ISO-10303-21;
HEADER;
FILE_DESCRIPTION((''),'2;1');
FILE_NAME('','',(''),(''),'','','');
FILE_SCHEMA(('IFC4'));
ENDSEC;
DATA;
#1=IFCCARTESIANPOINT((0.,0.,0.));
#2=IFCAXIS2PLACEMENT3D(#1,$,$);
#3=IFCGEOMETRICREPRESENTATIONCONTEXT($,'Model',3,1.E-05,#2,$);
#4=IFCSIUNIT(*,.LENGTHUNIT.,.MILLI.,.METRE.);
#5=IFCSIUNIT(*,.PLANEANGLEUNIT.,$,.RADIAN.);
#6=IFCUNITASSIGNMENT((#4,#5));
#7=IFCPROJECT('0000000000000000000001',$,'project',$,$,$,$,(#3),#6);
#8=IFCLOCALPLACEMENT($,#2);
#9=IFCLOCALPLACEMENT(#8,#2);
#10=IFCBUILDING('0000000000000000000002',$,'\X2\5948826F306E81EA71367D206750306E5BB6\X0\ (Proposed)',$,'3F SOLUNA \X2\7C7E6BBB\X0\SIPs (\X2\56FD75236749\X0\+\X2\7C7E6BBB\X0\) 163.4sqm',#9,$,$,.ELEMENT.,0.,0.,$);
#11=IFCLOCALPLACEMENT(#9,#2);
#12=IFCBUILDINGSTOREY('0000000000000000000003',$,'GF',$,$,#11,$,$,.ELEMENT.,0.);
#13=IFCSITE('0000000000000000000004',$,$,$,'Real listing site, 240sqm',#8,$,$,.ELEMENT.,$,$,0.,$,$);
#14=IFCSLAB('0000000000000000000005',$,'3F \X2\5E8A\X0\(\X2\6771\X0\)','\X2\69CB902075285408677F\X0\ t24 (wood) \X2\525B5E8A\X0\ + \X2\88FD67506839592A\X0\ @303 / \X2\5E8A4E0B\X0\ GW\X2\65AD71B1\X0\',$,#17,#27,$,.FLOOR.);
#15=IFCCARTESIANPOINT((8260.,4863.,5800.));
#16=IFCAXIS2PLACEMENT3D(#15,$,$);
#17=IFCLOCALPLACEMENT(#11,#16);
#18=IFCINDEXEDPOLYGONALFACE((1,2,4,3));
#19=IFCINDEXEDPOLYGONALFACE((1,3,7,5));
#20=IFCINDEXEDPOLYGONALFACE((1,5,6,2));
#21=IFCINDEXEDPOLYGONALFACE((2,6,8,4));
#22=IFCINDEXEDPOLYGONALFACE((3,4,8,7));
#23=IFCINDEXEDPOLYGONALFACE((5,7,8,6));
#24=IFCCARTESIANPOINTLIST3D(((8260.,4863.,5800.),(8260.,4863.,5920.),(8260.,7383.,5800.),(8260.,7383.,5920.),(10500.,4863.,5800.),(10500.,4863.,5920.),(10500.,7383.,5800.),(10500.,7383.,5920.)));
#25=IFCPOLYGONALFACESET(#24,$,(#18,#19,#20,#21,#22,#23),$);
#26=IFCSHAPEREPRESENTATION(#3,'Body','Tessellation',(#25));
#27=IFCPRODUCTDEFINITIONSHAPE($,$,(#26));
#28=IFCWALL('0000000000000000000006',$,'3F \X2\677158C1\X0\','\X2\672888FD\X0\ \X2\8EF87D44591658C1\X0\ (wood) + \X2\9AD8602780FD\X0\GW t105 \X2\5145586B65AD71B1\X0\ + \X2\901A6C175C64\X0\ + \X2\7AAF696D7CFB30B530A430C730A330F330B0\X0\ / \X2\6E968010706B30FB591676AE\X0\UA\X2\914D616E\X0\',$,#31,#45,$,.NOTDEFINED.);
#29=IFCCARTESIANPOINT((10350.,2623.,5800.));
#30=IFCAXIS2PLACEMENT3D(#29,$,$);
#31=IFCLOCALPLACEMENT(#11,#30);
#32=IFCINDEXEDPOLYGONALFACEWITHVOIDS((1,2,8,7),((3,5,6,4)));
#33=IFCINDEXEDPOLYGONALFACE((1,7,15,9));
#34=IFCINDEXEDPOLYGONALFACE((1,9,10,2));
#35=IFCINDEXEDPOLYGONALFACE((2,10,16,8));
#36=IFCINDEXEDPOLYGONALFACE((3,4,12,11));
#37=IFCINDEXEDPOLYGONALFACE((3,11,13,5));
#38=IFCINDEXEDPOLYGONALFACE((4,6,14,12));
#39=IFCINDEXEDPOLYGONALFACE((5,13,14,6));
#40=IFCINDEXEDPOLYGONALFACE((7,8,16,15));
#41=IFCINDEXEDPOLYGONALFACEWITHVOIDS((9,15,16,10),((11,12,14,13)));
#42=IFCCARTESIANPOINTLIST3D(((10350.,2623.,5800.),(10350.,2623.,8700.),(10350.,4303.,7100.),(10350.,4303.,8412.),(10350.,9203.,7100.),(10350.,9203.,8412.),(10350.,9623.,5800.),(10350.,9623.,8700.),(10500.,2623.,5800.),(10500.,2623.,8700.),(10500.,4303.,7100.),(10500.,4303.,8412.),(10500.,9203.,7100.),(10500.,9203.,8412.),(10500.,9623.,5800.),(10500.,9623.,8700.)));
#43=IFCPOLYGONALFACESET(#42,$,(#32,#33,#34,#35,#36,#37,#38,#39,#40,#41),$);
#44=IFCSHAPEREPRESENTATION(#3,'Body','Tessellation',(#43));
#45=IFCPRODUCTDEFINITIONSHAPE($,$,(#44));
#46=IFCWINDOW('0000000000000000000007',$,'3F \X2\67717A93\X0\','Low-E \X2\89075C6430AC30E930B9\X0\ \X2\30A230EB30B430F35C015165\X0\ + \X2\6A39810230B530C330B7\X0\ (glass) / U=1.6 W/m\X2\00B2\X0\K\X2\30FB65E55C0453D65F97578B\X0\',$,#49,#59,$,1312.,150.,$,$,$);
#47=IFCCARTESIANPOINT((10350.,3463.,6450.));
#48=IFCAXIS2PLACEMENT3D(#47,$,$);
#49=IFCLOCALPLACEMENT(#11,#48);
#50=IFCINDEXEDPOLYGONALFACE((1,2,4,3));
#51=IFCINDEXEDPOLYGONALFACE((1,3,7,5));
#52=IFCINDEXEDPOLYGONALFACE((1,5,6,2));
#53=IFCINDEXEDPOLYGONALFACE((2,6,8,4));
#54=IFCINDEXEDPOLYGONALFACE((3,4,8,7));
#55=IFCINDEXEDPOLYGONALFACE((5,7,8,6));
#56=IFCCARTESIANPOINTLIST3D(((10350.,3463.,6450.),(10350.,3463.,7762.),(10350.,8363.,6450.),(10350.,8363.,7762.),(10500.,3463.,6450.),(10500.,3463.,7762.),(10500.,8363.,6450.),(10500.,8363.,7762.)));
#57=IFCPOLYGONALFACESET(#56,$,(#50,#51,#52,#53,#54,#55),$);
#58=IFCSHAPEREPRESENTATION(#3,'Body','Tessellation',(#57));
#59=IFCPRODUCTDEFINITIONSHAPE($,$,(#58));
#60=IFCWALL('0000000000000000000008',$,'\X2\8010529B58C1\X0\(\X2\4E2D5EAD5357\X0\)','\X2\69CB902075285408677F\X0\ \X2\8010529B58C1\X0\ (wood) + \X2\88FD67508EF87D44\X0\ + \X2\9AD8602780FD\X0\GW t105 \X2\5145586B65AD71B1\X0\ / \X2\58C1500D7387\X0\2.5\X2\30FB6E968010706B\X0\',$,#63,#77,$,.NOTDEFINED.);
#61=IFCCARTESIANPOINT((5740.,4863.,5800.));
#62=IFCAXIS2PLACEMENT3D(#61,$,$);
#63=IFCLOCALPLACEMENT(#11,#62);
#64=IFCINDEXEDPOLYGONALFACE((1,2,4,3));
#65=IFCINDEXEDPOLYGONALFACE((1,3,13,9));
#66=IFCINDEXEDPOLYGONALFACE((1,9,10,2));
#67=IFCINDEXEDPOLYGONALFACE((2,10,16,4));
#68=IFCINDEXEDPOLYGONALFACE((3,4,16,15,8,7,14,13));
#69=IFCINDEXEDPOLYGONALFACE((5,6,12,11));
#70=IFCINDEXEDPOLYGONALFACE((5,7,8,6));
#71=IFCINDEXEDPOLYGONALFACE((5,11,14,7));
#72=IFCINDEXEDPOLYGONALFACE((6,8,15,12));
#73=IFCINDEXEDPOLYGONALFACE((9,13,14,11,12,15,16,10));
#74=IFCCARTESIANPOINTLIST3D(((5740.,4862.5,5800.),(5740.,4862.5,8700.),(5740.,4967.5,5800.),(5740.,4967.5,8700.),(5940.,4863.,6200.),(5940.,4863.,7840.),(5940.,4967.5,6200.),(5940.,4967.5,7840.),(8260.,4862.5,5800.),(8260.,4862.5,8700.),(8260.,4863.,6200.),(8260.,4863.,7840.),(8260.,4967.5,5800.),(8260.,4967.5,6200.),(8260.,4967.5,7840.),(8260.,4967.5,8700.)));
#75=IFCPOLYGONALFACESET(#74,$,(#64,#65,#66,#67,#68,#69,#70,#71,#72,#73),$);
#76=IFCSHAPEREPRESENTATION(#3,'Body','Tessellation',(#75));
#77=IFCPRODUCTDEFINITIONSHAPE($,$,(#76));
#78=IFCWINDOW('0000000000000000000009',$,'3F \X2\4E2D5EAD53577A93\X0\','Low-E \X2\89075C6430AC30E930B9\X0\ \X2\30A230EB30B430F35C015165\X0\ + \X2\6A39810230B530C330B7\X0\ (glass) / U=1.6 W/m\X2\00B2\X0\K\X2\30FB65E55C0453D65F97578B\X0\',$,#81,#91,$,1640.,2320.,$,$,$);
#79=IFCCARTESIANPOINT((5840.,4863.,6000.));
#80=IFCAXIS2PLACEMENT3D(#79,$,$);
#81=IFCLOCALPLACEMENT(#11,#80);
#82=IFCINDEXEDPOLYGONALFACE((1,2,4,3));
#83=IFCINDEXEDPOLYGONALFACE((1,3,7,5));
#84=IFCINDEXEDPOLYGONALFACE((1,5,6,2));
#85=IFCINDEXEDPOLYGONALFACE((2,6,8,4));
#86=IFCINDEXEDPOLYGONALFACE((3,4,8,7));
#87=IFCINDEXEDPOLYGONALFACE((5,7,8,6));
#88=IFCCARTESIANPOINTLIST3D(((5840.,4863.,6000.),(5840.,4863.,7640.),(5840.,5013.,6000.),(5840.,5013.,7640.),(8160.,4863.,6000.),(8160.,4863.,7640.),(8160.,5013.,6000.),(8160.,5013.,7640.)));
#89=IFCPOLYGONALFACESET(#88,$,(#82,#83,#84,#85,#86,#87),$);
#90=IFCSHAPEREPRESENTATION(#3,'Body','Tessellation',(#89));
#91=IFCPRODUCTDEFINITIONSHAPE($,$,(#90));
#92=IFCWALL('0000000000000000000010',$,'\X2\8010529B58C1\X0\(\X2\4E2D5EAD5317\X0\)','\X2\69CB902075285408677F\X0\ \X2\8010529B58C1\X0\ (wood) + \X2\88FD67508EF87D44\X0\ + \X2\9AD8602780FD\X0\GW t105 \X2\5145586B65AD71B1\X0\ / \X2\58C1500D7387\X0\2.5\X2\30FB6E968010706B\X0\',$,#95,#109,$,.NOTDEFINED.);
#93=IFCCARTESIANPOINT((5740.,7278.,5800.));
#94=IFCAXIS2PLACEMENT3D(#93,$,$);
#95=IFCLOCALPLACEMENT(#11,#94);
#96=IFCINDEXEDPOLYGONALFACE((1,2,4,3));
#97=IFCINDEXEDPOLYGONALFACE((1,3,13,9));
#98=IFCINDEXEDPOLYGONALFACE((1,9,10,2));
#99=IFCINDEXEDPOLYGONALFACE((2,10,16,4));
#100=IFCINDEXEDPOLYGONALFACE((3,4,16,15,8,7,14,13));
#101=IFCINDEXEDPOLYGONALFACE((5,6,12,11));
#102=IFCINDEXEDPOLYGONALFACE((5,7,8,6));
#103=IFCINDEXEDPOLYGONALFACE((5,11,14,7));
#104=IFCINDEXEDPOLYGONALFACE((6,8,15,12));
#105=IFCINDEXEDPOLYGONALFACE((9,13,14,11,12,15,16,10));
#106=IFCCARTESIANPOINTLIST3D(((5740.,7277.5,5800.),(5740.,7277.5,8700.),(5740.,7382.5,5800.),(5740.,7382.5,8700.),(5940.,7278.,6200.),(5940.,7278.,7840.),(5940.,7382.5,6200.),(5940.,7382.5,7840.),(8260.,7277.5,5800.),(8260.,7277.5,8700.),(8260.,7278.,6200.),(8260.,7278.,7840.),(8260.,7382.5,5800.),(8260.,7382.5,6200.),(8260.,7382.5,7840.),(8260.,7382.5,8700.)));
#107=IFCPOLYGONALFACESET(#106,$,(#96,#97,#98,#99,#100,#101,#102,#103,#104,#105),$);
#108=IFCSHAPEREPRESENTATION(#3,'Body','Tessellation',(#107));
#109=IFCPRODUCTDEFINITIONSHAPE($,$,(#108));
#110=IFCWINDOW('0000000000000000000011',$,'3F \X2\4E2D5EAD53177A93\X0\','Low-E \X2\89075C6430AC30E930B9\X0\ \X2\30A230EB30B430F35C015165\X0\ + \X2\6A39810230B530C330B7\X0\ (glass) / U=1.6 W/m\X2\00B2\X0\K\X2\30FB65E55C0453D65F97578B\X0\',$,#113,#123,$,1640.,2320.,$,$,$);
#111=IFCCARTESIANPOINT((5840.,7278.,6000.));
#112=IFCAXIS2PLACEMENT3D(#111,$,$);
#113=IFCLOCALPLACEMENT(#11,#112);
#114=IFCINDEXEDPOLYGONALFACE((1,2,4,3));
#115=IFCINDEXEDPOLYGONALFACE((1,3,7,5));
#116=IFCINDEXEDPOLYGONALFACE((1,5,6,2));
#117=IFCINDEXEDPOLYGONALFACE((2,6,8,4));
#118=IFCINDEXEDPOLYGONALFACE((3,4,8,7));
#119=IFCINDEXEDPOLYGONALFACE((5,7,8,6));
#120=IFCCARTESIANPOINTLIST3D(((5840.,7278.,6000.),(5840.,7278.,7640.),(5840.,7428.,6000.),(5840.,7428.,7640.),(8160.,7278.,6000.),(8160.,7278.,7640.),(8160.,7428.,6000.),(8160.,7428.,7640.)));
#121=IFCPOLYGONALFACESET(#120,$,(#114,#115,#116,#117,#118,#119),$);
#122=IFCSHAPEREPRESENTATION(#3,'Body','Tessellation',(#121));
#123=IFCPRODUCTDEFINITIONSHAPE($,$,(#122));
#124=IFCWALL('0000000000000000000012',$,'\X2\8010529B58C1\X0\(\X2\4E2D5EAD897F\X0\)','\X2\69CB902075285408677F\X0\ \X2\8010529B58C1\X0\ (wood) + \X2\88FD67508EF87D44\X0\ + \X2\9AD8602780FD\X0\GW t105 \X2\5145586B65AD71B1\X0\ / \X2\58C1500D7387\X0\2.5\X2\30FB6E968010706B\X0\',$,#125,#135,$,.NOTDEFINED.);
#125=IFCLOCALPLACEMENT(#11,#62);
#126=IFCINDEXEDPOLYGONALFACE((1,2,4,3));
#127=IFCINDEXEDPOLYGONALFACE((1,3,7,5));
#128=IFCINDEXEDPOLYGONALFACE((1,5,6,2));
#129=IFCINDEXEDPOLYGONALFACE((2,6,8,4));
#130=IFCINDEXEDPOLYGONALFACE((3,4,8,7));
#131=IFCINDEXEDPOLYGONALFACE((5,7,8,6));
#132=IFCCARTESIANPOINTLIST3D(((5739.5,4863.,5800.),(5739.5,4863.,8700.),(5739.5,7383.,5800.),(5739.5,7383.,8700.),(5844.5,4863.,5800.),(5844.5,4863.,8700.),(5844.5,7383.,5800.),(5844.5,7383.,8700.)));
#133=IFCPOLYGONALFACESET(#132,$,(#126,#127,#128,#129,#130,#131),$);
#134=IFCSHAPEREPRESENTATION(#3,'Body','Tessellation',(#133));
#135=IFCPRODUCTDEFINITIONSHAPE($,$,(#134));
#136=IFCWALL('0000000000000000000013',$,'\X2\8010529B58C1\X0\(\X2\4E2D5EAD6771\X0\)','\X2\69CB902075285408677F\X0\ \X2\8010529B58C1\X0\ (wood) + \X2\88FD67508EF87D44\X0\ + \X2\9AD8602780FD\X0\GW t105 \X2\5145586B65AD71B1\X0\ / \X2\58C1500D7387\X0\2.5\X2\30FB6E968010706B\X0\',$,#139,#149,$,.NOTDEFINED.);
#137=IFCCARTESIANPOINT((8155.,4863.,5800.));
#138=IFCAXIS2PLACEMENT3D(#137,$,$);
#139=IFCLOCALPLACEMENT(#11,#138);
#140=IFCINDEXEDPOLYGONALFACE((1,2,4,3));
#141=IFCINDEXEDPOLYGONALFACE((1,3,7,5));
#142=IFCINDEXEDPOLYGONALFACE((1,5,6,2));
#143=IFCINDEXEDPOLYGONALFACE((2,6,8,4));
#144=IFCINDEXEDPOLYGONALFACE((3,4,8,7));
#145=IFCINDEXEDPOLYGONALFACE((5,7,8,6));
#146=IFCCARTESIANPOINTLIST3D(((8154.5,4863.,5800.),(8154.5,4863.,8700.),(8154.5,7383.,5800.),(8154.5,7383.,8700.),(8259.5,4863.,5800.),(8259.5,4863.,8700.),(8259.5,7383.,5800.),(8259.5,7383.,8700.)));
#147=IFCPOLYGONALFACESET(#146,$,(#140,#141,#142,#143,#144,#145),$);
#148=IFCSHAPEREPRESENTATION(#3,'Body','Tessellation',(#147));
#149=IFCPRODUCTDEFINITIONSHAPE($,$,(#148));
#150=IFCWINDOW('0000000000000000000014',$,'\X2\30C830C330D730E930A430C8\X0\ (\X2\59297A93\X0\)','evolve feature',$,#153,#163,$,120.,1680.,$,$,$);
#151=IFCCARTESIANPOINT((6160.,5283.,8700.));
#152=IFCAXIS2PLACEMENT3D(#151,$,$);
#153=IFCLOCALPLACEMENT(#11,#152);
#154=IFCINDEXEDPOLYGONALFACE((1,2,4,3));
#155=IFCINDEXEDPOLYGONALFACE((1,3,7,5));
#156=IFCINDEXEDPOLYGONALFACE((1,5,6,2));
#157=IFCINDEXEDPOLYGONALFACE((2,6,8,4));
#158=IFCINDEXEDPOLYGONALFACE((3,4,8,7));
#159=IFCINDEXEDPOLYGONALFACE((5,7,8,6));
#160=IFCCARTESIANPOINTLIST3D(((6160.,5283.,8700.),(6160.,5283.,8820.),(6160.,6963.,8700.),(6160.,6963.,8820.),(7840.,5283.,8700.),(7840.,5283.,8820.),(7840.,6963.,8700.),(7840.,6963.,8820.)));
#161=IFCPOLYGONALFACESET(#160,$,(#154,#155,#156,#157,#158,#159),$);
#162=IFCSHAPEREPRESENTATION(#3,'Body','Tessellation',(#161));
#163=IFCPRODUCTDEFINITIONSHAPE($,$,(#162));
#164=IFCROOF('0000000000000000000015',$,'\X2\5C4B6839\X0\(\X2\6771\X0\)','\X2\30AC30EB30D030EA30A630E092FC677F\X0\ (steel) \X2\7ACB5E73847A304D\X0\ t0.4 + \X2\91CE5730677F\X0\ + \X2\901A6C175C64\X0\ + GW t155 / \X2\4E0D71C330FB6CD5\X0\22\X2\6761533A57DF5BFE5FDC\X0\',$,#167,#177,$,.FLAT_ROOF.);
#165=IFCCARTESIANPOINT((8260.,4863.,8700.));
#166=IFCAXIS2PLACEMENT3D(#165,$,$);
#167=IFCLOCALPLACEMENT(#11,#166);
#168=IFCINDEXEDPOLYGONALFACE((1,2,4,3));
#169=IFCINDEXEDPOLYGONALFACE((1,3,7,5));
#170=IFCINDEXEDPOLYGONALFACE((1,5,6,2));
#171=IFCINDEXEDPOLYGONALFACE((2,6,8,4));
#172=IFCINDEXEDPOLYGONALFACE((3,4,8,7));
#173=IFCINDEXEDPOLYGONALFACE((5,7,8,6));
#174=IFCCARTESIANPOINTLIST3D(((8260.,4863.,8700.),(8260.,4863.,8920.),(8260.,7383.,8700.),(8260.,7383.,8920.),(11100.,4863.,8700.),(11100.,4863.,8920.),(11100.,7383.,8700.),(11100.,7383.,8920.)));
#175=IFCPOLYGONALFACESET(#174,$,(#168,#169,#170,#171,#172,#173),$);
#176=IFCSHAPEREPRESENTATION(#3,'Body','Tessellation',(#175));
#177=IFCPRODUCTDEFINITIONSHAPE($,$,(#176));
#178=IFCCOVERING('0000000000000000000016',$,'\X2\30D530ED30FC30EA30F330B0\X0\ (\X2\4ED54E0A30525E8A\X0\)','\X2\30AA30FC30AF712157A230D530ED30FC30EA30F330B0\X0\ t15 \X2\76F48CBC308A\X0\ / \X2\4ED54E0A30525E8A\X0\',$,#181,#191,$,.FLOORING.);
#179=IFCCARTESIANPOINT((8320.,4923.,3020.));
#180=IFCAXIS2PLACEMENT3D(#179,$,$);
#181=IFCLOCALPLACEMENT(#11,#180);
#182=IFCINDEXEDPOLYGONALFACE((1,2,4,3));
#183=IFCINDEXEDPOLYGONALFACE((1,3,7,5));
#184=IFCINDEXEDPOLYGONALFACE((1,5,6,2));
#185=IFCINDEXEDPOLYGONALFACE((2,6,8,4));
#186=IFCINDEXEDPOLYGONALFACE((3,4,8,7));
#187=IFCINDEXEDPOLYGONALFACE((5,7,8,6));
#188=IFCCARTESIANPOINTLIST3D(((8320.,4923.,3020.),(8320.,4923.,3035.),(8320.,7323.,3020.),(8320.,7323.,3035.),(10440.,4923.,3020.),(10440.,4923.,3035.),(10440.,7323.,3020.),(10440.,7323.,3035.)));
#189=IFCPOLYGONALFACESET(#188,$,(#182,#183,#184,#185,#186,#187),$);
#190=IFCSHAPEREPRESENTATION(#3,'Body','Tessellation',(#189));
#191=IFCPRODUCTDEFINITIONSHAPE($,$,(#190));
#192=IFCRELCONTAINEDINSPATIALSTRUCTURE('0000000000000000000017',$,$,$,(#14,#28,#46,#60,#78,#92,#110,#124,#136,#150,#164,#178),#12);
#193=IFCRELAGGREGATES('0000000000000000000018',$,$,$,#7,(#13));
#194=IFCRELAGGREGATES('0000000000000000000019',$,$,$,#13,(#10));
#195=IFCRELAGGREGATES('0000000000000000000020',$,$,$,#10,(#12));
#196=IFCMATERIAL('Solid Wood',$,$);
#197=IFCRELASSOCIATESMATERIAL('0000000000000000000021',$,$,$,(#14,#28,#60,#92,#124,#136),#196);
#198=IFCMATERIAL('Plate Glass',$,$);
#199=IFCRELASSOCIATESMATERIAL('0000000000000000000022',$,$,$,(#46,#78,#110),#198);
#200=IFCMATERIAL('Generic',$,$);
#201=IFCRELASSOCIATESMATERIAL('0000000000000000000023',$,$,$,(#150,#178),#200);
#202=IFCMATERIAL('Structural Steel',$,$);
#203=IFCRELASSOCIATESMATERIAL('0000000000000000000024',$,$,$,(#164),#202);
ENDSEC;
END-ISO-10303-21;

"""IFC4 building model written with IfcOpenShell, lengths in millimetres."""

from ifc_helpers import new_model, si_unit, frame, frame_2d, origin, place, context, project, spatial, rectangle, extrude, material, element, fill, save


model = new_model("IFC4")

# Units and contexts
model_context = context("Model", 3, precision=1e-05, world=origin())
ifc_project = project(units=[si_unit("LENGTHUNIT", "METRE", prefix="MILLI"), si_unit("PLANEANGLEUNIT", "RADIAN")], contexts=[model_context])

# Site, building, storey
site_placement = place(None, origin())
site = spatial("IfcSite", under=ifc_project, at=site_placement, ObjectType="Real listing site, 240sqm", CompositionType="ELEMENT", RefElevation=0.0)
building_placement = place(site_placement, origin())
building = spatial("IfcBuilding", under=site, at=building_placement, Name="奈良の自然素材の家 (Proposed)", ObjectType="3F SOLUNA 籾殻SIPs (国産杉+籾殻) 163.4sqm", CompositionType="ELEMENT", ElevationOfRefHeight=0.0, ElevationOfTerrain=0.0)
storey_placement = place(building_placement, origin())
storey = spatial("IfcBuildingStorey", under=building, at=storey_placement, Name="GF", CompositionType="ELEMENT", Elevation=0.0)

# Slab
ifc_material_1 = material(Name="Solid Wood")
slab_placement = place(storey_placement, frame((8260.0, 4863.0, 5800.0)))
element("IfcSlab", 1, at=slab_placement, inside=storey, material=ifc_material_1, Name="3F 床(東)", Description="構造用合板 t24 (wood) 剛床 + 製材根太 @303 / 床下 GW断熱", PredefinedType="FLOOR", context=model_context, shape_type="SweptSolid", body=[
    extrude(rectangle(XDim=2240.0, YDim=2520.0, at=frame_2d((1120.0, 1260.0))), frame((8260.0, 4863.0, 5800.0)), (0.0, 0.0, 1.0), 120.0),
])

# Walls, openings, windows
wall_1_placement = place(storey_placement, frame((10350.0, 2623.0, 5800.0)))
wall_1 = element("IfcWall", 2, at=wall_1_placement, inside=storey, material=ifc_material_1, Name="3F 東壁", Description="木製 軸組外壁 (wood) + 高性能GW t105 充填断熱 + 通気層 + 窯業系サイディング / 準耐火・外皮UA配慮", PredefinedType="NOTDEFINED", context=model_context, shape_type="SweptSolid", body=[
    extrude(rectangle(XDim=150.0, YDim=7000.0, at=frame_2d((75.0, 3500.0))), frame((10350.0, 2623.0, 5800.0)), (0.0, 0.0, 1.0), 2900.0),
])
opening_1_placement = place(storey_placement, frame((10350.0, 3463.0, 6450.0)))
opening_1 = element("IfcOpeningElement", 3, at=opening_1_placement, cuts=wall_1, PredefinedType="NOTDEFINED", context=model_context, shape_type="SweptSolid", body=[
    extrude(rectangle(XDim=150.0, YDim=4900.0, at=frame_2d((75.0, 2450.0))), frame((10350.0, 3463.0, 6450.0)), (0.0, 0.0, 1.0), 1312.0),
])
ifc_material_2 = material(Name="Plate Glass")
window_1_placement = place(storey_placement, frame((10350.0, 3463.0, 6450.0)))
window_1 = element("IfcWindow", 4, at=window_1_placement, inside=storey, material=ifc_material_2, Name="3F 東窓", Description="Low-E 複層ガラス アルゴン封入 + 樹脂サッシ (glass) / U=1.6 W/m²K・日射取得型", OverallHeight=1312.0, OverallWidth=150.0, context=model_context, shape_type="SweptSolid", body=[
    extrude(rectangle(XDim=150.0, YDim=4900.0, at=frame_2d((75.0, 2450.0))), frame((10350.0, 3463.0, 6450.0)), (0.0, 0.0, 1.0), 1312.0),
])
fill(opening_1, window_1)
wall_2_placement = place(storey_placement, frame((5740.0, 4863.0, 5800.0)))
wall_2 = element("IfcWall", 5, at=wall_2_placement, inside=storey, material=ifc_material_1, Name="耐力壁(中庭南)", Description="構造用合板 耐力壁 (wood) + 製材軸組 + 高性能GW t105 充填断熱 / 壁倍率2.5・準耐火", PredefinedType="NOTDEFINED", context=model_context, shape_type="SweptSolid", body=[
    extrude(rectangle(XDim=2520.0, YDim=105.0, at=frame_2d((1260.0, 52.0))), frame((5740.0, 4863.0, 5800.0)), (0.0, 0.0, 1.0), 2900.0),
])
opening_2_placement = place(storey_placement, frame((5840.0, 4863.0, 6000.0)))
opening_2 = element("IfcOpeningElement", 6, at=opening_2_placement, cuts=wall_2, PredefinedType="NOTDEFINED", context=model_context, shape_type="SweptSolid", body=[
    extrude(rectangle(XDim=2320.0, YDim=150.0, at=frame_2d((1160.0, 75.0))), frame((5840.0, 4863.0, 6000.0)), (0.0, 0.0, 1.0), 1640.0),
])
window_2_placement = place(storey_placement, frame((5840.0, 4863.0, 6000.0)))
window_2 = element("IfcWindow", 7, at=window_2_placement, inside=storey, material=ifc_material_2, Name="3F 中庭南窓", Description="Low-E 複層ガラス アルゴン封入 + 樹脂サッシ (glass) / U=1.6 W/m²K・日射取得型", OverallHeight=1640.0, OverallWidth=2320.0, context=model_context, shape_type="SweptSolid", body=[
    extrude(rectangle(XDim=2320.0, YDim=150.0, at=frame_2d((1160.0, 75.0))), frame((5840.0, 4863.0, 6000.0)), (0.0, 0.0, 1.0), 1640.0),
])
fill(opening_2, window_2)
wall_3_placement = place(storey_placement, frame((5740.0, 7278.0, 5800.0)))
wall_3 = element("IfcWall", 8, at=wall_3_placement, inside=storey, material=ifc_material_1, Name="耐力壁(中庭北)", Description="構造用合板 耐力壁 (wood) + 製材軸組 + 高性能GW t105 充填断熱 / 壁倍率2.5・準耐火", PredefinedType="NOTDEFINED", context=model_context, shape_type="SweptSolid", body=[
    extrude(rectangle(XDim=2520.0, YDim=105.0, at=frame_2d((1260.0, 52.0))), frame((5740.0, 7278.0, 5800.0)), (0.0, 0.0, 1.0), 2900.0),
])
opening_3_placement = place(storey_placement, frame((5840.0, 7278.0, 6000.0)))
opening_3 = element("IfcOpeningElement", 9, at=opening_3_placement, cuts=wall_3, PredefinedType="NOTDEFINED", context=model_context, shape_type="SweptSolid", body=[
    extrude(rectangle(XDim=2320.0, YDim=150.0, at=frame_2d((1160.0, 75.0))), frame((5840.0, 7278.0, 6000.0)), (0.0, 0.0, 1.0), 1640.0),
])
window_3_placement = place(storey_placement, frame((5840.0, 7278.0, 6000.0)))
window_3 = element("IfcWindow", 10, at=window_3_placement, inside=storey, material=ifc_material_2, Name="3F 中庭北窓", Description="Low-E 複層ガラス アルゴン封入 + 樹脂サッシ (glass) / U=1.6 W/m²K・日射取得型", OverallHeight=1640.0, OverallWidth=2320.0, context=model_context, shape_type="SweptSolid", body=[
    extrude(rectangle(XDim=2320.0, YDim=150.0, at=frame_2d((1160.0, 75.0))), frame((5840.0, 7278.0, 6000.0)), (0.0, 0.0, 1.0), 1640.0),
])
fill(opening_3, window_3)

# Walls
wall_4_placement = place(storey_placement, frame((5740.0, 4863.0, 5800.0)))
element("IfcWall", 11, at=wall_4_placement, inside=storey, material=ifc_material_1, Name="耐力壁(中庭西)", Description="構造用合板 耐力壁 (wood) + 製材軸組 + 高性能GW t105 充填断熱 / 壁倍率2.5・準耐火", PredefinedType="NOTDEFINED", context=model_context, shape_type="SweptSolid", body=[
    extrude(rectangle(XDim=105.0, YDim=2520.0, at=frame_2d((52.0, 1260.0))), frame((5740.0, 4863.0, 5800.0)), (0.0, 0.0, 1.0), 2900.0),
])
wall_5_placement = place(storey_placement, frame((8155.0, 4863.0, 5800.0)))
element("IfcWall", 12, at=wall_5_placement, inside=storey, material=ifc_material_1, Name="耐力壁(中庭東)", Description="構造用合板 耐力壁 (wood) + 製材軸組 + 高性能GW t105 充填断熱 / 壁倍率2.5・準耐火", PredefinedType="NOTDEFINED", context=model_context, shape_type="SweptSolid", body=[
    extrude(rectangle(XDim=105.0, YDim=2520.0, at=frame_2d((52.0, 1260.0))), frame((8155.0, 4863.0, 5800.0)), (0.0, 0.0, 1.0), 2900.0),
])

# Window
ifc_material_3 = material(Name="Generic")
window_4_placement = place(storey_placement, frame((6160.0, 5283.0, 8700.0)))
element("IfcWindow", 13, at=window_4_placement, inside=storey, material=ifc_material_3, Name="トップライト (天窓)", Description="evolve feature", OverallHeight=120.0, OverallWidth=1680.0, context=model_context, shape_type="SweptSolid", body=[
    extrude(rectangle(XDim=1680.0, YDim=1680.0, at=frame_2d((840.0, 840.0))), frame((6160.0, 5283.0, 8700.0)), (0.0, 0.0, 1.0), 120.0),
])

# Roof
ifc_material_4 = material(Name="Structural Steel")
for number, where, name in (
    (14, (8260.0, 4863.0, 8700.0), "屋根(東)"),
):
    element("IfcRoof", number, at=place(storey_placement, frame(where)), inside=storey, material=ifc_material_4, Name=name, Description="ガルバリウム鋼板 (steel) 立平葺き t0.4 + 野地板 + 通気層 + GW t155 / 不燃・法22条区域対応", PredefinedType="FLAT_ROOF", context=model_context, shape_type="SweptSolid", body=[
        extrude(rectangle(XDim=2840.0, YDim=2520.0, at=frame_2d((1420.0, 1260.0))), frame((8260.0, 4863.0, 8700.0)), (0.0, 0.0, 1.0), 220.0),
    ])

# Covering
covering_1_placement = place(storey_placement, frame((8320.0, 4923.0, 3020.0)))
element("IfcCovering", 15, at=covering_1_placement, inside=storey, material=ifc_material_3, Name="フローリング (仕上げ床)", Description="オーク無垢フローリング t15 直貼り / 仕上げ床", PredefinedType="FLOORING", context=model_context, shape_type="SweptSolid", body=[
    extrude(rectangle(XDim=2120.0, YDim=2400.0, at=frame_2d((1060.0, 1200.0))), frame((8320.0, 4923.0, 3020.0)), (0.0, 0.0, 1.0), 15.0),
])

save(model, "model.ifc")
